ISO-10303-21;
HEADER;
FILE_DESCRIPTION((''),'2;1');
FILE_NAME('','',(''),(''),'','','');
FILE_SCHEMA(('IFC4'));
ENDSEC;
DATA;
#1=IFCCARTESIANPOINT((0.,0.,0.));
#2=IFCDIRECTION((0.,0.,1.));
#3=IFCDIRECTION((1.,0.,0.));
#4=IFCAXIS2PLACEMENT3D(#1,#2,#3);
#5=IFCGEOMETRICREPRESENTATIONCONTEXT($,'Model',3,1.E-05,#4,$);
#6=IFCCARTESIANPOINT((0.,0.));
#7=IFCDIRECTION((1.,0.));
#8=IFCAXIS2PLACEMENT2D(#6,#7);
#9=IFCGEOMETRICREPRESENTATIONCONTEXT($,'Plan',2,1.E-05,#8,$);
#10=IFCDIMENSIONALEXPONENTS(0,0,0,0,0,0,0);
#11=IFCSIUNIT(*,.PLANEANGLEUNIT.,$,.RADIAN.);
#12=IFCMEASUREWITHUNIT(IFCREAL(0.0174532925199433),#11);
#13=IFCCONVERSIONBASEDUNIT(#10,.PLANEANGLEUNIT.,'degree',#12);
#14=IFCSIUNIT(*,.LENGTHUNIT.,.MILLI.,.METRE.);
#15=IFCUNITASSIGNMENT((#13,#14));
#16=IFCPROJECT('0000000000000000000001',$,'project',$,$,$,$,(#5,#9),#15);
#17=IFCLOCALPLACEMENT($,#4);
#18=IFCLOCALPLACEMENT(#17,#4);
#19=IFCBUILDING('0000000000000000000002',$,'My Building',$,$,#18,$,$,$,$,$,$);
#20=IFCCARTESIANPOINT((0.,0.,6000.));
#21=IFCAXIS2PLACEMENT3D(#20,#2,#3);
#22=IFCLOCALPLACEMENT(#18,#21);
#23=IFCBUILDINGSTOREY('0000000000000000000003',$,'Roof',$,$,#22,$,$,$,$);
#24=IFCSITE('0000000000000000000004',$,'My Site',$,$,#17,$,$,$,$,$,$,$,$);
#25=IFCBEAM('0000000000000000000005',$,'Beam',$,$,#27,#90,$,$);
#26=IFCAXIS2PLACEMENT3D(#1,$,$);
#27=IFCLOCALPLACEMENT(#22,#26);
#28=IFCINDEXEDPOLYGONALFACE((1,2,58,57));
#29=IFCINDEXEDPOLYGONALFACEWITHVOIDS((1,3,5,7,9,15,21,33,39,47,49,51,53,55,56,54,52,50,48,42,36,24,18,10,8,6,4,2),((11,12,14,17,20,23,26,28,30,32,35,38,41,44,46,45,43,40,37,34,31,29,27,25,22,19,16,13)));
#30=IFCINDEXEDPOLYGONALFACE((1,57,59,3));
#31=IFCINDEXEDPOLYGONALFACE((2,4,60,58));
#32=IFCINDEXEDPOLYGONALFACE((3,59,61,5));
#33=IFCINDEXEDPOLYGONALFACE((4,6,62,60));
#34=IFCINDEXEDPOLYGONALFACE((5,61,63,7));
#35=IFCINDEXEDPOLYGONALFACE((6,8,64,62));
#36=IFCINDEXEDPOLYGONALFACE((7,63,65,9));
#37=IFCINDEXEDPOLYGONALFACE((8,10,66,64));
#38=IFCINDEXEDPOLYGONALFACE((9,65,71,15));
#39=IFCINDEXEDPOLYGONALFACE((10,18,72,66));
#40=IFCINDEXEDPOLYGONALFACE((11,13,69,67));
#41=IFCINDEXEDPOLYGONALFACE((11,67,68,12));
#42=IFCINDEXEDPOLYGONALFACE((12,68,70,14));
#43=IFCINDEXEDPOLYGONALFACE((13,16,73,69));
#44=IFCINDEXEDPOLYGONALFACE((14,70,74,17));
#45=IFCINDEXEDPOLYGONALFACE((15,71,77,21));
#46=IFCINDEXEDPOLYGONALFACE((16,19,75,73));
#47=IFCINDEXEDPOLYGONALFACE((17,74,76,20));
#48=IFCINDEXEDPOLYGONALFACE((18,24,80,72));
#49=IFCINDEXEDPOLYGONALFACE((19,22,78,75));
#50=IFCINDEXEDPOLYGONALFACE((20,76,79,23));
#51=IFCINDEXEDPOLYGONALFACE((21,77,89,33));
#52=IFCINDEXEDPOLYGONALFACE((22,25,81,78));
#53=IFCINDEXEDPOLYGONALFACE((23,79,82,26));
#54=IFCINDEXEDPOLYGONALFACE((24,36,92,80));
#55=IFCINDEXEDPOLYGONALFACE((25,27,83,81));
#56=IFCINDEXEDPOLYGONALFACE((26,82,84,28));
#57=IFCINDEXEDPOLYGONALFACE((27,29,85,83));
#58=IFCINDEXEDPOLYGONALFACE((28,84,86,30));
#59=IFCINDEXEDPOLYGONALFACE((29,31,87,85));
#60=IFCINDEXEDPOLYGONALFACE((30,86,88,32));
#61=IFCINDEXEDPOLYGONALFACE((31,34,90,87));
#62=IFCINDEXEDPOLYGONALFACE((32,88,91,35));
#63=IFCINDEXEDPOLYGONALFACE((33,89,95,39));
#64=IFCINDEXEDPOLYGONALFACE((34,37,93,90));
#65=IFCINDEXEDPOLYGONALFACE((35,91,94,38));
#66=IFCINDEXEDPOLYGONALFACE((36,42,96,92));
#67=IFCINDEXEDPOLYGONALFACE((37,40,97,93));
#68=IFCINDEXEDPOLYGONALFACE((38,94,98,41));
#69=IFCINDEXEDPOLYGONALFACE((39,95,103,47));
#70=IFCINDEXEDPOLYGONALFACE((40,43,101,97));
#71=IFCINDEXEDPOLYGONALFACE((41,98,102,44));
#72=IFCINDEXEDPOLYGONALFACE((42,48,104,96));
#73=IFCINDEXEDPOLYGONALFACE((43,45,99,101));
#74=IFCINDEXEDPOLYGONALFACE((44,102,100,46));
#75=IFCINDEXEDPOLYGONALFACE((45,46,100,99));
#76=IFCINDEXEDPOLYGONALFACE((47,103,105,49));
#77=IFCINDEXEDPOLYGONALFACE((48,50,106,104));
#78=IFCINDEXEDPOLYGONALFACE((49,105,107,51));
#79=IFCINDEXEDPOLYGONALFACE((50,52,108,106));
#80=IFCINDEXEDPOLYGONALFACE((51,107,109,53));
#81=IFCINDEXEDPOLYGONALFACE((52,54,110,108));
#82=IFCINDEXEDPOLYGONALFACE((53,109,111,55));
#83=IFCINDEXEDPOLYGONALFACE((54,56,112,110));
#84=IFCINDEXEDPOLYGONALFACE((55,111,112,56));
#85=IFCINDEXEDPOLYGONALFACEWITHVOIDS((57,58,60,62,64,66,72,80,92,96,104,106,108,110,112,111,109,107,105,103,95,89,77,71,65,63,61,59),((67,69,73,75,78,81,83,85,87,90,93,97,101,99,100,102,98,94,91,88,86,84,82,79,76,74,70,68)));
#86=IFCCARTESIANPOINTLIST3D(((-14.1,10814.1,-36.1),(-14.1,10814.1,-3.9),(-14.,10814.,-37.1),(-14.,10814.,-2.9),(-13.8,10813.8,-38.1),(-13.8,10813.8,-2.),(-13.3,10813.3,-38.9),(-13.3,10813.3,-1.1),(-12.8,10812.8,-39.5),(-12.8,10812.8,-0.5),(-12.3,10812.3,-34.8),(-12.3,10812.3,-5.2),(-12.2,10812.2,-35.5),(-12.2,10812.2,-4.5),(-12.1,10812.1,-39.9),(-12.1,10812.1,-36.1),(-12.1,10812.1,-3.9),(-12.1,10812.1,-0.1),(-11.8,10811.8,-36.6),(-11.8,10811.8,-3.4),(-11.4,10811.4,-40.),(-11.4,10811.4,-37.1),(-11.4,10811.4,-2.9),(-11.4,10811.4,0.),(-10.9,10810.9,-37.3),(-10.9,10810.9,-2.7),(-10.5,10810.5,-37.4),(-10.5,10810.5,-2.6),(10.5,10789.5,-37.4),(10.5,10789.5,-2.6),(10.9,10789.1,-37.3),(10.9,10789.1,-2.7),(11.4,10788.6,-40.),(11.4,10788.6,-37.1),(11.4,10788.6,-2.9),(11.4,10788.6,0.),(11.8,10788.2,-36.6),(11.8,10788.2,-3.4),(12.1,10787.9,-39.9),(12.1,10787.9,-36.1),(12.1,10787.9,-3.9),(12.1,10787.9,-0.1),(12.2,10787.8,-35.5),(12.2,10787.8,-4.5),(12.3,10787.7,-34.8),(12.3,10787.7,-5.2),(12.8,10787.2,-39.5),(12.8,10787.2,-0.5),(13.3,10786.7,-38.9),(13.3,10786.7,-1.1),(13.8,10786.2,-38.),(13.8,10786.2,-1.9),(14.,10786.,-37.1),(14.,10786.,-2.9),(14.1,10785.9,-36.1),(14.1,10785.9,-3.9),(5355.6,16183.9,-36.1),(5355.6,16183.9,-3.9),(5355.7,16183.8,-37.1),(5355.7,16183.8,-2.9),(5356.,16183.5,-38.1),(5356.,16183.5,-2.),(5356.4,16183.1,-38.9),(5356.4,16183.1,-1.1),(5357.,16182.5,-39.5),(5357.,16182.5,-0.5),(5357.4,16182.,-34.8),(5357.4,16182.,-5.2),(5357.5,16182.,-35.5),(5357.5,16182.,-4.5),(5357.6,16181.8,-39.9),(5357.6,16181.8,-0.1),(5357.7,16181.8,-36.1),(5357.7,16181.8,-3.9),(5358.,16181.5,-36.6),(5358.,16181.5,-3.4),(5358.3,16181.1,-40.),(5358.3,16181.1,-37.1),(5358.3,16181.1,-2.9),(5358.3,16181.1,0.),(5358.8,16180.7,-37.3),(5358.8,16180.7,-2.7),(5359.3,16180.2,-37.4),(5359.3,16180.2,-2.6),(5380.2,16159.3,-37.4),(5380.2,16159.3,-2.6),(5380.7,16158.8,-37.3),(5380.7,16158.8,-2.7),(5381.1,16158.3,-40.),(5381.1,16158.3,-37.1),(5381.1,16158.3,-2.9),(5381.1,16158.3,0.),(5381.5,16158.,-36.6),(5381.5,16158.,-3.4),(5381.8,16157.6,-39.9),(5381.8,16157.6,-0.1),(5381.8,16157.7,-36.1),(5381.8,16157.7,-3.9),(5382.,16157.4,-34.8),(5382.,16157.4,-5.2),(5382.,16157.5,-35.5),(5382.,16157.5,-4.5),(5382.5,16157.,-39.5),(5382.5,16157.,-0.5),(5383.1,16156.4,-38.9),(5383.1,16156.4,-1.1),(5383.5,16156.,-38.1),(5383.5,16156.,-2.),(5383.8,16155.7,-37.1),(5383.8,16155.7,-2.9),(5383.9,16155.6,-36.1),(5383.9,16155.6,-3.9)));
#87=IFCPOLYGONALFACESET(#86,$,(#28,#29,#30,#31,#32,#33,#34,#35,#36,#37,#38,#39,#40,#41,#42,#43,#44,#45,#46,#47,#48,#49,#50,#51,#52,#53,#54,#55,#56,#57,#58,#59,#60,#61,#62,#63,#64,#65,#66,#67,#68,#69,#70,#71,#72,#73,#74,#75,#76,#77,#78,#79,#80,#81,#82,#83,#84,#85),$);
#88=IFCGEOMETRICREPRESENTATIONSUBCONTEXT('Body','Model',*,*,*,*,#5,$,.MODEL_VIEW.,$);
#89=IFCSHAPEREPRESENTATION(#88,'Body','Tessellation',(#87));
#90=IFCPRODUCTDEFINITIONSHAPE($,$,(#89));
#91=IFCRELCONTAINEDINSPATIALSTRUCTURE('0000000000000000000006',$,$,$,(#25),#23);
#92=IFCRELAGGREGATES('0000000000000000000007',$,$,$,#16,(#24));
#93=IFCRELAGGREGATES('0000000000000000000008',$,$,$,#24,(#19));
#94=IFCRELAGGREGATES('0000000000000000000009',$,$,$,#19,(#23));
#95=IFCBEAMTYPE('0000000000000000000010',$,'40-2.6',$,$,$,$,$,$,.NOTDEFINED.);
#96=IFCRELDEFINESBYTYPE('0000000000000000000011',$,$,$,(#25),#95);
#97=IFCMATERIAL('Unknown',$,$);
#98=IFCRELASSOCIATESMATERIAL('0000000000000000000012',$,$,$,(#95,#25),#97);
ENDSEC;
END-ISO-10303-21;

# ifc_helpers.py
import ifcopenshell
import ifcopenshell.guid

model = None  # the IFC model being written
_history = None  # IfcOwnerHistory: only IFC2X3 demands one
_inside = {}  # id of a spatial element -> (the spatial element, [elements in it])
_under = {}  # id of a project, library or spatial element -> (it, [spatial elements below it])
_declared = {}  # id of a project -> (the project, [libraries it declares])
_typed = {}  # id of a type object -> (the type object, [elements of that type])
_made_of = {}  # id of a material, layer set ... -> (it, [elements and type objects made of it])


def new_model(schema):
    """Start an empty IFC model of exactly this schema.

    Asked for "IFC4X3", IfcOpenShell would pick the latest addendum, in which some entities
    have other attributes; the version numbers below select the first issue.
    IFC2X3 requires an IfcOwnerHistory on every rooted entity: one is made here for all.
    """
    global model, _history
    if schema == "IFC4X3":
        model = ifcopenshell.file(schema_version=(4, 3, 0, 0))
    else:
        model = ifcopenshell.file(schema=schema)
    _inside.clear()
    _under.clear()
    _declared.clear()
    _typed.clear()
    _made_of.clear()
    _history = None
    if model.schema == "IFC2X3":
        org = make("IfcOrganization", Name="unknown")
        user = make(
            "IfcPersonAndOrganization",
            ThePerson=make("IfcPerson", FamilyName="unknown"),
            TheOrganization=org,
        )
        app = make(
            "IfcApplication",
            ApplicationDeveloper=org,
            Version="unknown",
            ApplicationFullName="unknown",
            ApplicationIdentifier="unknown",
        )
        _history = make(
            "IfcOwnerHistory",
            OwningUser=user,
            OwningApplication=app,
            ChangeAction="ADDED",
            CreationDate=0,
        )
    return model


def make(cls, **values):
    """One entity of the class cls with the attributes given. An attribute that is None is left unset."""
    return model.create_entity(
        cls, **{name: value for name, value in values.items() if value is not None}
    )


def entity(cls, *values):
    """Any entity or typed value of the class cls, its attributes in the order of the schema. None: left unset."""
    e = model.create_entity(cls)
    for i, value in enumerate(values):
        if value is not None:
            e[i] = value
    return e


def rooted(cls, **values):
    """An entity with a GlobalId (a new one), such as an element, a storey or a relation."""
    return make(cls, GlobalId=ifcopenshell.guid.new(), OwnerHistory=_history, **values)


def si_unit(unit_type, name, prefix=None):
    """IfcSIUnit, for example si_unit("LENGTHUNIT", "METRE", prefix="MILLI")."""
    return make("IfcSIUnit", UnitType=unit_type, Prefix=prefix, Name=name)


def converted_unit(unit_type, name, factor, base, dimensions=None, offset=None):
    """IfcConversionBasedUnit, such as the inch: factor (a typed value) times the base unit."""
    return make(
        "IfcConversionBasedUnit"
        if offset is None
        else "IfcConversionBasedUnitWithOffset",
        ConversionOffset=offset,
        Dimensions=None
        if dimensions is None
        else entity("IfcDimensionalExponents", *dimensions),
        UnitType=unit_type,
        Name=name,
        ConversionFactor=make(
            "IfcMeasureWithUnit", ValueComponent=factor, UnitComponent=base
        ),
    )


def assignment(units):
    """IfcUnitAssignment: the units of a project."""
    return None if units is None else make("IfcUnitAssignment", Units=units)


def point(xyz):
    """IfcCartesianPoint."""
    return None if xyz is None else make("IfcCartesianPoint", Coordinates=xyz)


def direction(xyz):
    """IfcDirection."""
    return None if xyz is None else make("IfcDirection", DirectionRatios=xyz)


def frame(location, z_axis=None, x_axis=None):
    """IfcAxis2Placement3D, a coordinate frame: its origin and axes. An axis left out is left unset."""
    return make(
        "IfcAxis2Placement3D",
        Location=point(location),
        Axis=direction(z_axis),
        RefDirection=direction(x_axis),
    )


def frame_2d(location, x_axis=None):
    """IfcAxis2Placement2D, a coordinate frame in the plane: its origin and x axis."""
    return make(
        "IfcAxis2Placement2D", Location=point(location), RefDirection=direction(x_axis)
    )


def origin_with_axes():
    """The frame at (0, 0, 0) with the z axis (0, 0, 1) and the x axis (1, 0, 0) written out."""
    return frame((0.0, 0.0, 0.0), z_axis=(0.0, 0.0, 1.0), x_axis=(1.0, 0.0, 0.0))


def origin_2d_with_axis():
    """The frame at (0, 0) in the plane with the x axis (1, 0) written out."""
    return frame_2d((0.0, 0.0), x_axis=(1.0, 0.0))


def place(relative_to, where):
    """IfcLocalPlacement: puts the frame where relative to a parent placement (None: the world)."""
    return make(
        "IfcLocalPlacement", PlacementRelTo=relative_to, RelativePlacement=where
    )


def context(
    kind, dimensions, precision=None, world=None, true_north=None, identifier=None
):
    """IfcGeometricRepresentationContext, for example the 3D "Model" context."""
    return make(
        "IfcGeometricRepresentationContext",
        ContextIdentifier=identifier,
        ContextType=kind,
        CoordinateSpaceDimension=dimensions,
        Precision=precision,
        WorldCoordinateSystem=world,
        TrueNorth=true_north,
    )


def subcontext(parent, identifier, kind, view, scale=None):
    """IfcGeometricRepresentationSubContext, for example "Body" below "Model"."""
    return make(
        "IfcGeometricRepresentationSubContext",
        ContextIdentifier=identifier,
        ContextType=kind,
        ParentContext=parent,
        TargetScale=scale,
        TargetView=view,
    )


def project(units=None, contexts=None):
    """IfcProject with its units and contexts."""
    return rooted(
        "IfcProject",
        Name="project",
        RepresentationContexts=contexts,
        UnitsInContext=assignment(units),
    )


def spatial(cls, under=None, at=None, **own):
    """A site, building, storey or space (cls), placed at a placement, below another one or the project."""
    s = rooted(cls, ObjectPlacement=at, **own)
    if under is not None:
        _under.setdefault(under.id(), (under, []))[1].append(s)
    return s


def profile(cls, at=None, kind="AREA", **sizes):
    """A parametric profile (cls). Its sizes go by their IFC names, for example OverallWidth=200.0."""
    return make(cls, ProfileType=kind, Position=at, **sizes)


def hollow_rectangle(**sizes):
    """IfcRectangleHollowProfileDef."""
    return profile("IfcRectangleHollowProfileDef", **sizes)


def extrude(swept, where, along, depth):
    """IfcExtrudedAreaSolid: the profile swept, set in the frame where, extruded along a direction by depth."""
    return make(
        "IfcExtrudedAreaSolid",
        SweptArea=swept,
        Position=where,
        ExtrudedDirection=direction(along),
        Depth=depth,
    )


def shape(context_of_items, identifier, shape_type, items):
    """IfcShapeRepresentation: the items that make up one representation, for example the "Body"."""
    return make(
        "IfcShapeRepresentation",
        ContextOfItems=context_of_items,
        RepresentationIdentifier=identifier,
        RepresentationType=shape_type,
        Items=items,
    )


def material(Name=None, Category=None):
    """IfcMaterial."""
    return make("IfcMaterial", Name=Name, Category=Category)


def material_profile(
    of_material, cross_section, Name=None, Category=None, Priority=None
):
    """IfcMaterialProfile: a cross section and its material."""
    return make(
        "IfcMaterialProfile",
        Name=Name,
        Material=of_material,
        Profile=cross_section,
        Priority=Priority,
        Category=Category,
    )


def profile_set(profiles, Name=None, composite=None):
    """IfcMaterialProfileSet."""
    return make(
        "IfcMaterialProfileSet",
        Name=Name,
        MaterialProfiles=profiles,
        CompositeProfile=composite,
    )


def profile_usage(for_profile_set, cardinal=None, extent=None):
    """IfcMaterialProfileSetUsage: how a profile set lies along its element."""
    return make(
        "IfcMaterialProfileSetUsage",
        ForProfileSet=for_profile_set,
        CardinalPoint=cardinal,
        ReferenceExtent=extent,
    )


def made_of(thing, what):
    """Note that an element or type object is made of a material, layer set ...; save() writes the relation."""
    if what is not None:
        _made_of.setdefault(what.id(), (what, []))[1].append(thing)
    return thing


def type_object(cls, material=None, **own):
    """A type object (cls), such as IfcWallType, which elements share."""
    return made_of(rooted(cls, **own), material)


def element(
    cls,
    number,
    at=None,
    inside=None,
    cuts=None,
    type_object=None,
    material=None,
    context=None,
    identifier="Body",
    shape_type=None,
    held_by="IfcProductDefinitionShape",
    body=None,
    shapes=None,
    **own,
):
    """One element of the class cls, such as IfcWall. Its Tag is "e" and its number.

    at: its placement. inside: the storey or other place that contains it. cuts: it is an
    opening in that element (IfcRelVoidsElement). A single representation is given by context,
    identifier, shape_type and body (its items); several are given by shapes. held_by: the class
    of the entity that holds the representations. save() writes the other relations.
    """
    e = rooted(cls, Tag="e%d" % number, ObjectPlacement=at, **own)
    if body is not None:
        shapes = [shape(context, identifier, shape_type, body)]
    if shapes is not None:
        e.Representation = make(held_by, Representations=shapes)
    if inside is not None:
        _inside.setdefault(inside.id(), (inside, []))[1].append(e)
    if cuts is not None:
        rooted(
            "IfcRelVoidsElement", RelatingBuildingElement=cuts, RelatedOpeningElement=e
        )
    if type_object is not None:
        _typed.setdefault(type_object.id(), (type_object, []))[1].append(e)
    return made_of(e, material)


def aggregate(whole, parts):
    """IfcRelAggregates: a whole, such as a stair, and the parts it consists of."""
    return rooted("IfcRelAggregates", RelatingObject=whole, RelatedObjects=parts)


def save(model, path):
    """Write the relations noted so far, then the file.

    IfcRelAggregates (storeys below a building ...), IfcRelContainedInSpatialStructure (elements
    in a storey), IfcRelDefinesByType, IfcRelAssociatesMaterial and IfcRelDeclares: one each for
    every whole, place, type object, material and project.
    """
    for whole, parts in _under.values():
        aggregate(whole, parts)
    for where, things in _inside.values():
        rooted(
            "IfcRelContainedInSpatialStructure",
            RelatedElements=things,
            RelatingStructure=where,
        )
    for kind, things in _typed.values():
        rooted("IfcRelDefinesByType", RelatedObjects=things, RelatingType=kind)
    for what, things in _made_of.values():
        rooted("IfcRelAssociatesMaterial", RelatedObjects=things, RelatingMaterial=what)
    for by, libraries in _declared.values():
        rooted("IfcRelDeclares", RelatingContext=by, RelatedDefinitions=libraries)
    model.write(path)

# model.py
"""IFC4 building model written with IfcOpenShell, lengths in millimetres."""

from ifc_helpers import new_model, entity, si_unit, converted_unit, frame, origin_with_axes, origin_2d_with_axis, place, context, subcontext, project, spatial, hollow_rectangle, extrude, material, material_profile, profile_set, profile_usage, type_object, element, save


model = new_model("IFC4")

# Units and contexts
model_context = context("Model", 3, precision=1e-05, world=origin_with_axes())
plan_context = context("Plan", 2, precision=1e-05, world=origin_2d_with_axis())
body_context = subcontext(model_context, "Body", "Model", "MODEL_VIEW")
ifc_project = project(units=[converted_unit("PLANEANGLEUNIT", "degree", entity("IfcReal", 0.0174532925199433), si_unit("PLANEANGLEUNIT", "RADIAN"), dimensions=[0, 0, 0, 0, 0, 0, 0]), si_unit("LENGTHUNIT", "METRE", prefix="MILLI")], contexts=[model_context, plan_context])

# Site, building, storey
site_placement = place(None, origin_with_axes())
site = spatial("IfcSite", under=ifc_project, at=site_placement, Name="My Site")
building_placement = place(site_placement, origin_with_axes())
building = spatial("IfcBuilding", under=site, at=building_placement, Name="My Building")
storey_placement = place(building_placement, frame((0.0, 0.0, 6000.0), z_axis=(0.0, 0.0, 1.0), x_axis=(1.0, 0.0, 0.0)))
storey = spatial("IfcBuildingStorey", under=building, at=storey_placement, Name="Roof")

# Beam
ifc_material = material(Name="Unknown")
ifc_material_profile_1 = material_profile(ifc_material, hollow_rectangle(XDim=40.0, YDim=40.0, WallThickness=2.6, InnerFilletRadius=2.6, OuterFilletRadius=3.9))
ifc_profile_set_1 = profile_set([ifc_material_profile_1])
beam_type_1 = type_object("IfcBeamType", Name="40-2.6", PredefinedType="NOTDEFINED", material=ifc_profile_set_1)
ifc_profile_usage_1 = profile_usage(ifc_profile_set_1, cardinal=8)
beam_1_placement = place(storey_placement, frame((0.0, 10800.0, 0.0), z_axis=(0.707107, 0.707107, 0.0), x_axis=(-0.707107, 0.707107, 0.0)))
element("IfcBeam", 1, at=beam_1_placement, inside=storey, type_object=beam_type_1, material=ifc_profile_usage_1, Name="Beam", context=body_context, shape_type="SweptSolid", body=[
    extrude(hollow_rectangle(XDim=40.0, YDim=40.0, WallThickness=2.6, InnerFilletRadius=2.6, OuterFilletRadius=3.9), frame((0.0, -20.0, 0.0), z_axis=(0.0, 0.0, 1.0), x_axis=(1.0, 0.0, 0.0)), (0.0, 0.0, 1.0), 7594.0),
])

save(model, "model.ifc")
